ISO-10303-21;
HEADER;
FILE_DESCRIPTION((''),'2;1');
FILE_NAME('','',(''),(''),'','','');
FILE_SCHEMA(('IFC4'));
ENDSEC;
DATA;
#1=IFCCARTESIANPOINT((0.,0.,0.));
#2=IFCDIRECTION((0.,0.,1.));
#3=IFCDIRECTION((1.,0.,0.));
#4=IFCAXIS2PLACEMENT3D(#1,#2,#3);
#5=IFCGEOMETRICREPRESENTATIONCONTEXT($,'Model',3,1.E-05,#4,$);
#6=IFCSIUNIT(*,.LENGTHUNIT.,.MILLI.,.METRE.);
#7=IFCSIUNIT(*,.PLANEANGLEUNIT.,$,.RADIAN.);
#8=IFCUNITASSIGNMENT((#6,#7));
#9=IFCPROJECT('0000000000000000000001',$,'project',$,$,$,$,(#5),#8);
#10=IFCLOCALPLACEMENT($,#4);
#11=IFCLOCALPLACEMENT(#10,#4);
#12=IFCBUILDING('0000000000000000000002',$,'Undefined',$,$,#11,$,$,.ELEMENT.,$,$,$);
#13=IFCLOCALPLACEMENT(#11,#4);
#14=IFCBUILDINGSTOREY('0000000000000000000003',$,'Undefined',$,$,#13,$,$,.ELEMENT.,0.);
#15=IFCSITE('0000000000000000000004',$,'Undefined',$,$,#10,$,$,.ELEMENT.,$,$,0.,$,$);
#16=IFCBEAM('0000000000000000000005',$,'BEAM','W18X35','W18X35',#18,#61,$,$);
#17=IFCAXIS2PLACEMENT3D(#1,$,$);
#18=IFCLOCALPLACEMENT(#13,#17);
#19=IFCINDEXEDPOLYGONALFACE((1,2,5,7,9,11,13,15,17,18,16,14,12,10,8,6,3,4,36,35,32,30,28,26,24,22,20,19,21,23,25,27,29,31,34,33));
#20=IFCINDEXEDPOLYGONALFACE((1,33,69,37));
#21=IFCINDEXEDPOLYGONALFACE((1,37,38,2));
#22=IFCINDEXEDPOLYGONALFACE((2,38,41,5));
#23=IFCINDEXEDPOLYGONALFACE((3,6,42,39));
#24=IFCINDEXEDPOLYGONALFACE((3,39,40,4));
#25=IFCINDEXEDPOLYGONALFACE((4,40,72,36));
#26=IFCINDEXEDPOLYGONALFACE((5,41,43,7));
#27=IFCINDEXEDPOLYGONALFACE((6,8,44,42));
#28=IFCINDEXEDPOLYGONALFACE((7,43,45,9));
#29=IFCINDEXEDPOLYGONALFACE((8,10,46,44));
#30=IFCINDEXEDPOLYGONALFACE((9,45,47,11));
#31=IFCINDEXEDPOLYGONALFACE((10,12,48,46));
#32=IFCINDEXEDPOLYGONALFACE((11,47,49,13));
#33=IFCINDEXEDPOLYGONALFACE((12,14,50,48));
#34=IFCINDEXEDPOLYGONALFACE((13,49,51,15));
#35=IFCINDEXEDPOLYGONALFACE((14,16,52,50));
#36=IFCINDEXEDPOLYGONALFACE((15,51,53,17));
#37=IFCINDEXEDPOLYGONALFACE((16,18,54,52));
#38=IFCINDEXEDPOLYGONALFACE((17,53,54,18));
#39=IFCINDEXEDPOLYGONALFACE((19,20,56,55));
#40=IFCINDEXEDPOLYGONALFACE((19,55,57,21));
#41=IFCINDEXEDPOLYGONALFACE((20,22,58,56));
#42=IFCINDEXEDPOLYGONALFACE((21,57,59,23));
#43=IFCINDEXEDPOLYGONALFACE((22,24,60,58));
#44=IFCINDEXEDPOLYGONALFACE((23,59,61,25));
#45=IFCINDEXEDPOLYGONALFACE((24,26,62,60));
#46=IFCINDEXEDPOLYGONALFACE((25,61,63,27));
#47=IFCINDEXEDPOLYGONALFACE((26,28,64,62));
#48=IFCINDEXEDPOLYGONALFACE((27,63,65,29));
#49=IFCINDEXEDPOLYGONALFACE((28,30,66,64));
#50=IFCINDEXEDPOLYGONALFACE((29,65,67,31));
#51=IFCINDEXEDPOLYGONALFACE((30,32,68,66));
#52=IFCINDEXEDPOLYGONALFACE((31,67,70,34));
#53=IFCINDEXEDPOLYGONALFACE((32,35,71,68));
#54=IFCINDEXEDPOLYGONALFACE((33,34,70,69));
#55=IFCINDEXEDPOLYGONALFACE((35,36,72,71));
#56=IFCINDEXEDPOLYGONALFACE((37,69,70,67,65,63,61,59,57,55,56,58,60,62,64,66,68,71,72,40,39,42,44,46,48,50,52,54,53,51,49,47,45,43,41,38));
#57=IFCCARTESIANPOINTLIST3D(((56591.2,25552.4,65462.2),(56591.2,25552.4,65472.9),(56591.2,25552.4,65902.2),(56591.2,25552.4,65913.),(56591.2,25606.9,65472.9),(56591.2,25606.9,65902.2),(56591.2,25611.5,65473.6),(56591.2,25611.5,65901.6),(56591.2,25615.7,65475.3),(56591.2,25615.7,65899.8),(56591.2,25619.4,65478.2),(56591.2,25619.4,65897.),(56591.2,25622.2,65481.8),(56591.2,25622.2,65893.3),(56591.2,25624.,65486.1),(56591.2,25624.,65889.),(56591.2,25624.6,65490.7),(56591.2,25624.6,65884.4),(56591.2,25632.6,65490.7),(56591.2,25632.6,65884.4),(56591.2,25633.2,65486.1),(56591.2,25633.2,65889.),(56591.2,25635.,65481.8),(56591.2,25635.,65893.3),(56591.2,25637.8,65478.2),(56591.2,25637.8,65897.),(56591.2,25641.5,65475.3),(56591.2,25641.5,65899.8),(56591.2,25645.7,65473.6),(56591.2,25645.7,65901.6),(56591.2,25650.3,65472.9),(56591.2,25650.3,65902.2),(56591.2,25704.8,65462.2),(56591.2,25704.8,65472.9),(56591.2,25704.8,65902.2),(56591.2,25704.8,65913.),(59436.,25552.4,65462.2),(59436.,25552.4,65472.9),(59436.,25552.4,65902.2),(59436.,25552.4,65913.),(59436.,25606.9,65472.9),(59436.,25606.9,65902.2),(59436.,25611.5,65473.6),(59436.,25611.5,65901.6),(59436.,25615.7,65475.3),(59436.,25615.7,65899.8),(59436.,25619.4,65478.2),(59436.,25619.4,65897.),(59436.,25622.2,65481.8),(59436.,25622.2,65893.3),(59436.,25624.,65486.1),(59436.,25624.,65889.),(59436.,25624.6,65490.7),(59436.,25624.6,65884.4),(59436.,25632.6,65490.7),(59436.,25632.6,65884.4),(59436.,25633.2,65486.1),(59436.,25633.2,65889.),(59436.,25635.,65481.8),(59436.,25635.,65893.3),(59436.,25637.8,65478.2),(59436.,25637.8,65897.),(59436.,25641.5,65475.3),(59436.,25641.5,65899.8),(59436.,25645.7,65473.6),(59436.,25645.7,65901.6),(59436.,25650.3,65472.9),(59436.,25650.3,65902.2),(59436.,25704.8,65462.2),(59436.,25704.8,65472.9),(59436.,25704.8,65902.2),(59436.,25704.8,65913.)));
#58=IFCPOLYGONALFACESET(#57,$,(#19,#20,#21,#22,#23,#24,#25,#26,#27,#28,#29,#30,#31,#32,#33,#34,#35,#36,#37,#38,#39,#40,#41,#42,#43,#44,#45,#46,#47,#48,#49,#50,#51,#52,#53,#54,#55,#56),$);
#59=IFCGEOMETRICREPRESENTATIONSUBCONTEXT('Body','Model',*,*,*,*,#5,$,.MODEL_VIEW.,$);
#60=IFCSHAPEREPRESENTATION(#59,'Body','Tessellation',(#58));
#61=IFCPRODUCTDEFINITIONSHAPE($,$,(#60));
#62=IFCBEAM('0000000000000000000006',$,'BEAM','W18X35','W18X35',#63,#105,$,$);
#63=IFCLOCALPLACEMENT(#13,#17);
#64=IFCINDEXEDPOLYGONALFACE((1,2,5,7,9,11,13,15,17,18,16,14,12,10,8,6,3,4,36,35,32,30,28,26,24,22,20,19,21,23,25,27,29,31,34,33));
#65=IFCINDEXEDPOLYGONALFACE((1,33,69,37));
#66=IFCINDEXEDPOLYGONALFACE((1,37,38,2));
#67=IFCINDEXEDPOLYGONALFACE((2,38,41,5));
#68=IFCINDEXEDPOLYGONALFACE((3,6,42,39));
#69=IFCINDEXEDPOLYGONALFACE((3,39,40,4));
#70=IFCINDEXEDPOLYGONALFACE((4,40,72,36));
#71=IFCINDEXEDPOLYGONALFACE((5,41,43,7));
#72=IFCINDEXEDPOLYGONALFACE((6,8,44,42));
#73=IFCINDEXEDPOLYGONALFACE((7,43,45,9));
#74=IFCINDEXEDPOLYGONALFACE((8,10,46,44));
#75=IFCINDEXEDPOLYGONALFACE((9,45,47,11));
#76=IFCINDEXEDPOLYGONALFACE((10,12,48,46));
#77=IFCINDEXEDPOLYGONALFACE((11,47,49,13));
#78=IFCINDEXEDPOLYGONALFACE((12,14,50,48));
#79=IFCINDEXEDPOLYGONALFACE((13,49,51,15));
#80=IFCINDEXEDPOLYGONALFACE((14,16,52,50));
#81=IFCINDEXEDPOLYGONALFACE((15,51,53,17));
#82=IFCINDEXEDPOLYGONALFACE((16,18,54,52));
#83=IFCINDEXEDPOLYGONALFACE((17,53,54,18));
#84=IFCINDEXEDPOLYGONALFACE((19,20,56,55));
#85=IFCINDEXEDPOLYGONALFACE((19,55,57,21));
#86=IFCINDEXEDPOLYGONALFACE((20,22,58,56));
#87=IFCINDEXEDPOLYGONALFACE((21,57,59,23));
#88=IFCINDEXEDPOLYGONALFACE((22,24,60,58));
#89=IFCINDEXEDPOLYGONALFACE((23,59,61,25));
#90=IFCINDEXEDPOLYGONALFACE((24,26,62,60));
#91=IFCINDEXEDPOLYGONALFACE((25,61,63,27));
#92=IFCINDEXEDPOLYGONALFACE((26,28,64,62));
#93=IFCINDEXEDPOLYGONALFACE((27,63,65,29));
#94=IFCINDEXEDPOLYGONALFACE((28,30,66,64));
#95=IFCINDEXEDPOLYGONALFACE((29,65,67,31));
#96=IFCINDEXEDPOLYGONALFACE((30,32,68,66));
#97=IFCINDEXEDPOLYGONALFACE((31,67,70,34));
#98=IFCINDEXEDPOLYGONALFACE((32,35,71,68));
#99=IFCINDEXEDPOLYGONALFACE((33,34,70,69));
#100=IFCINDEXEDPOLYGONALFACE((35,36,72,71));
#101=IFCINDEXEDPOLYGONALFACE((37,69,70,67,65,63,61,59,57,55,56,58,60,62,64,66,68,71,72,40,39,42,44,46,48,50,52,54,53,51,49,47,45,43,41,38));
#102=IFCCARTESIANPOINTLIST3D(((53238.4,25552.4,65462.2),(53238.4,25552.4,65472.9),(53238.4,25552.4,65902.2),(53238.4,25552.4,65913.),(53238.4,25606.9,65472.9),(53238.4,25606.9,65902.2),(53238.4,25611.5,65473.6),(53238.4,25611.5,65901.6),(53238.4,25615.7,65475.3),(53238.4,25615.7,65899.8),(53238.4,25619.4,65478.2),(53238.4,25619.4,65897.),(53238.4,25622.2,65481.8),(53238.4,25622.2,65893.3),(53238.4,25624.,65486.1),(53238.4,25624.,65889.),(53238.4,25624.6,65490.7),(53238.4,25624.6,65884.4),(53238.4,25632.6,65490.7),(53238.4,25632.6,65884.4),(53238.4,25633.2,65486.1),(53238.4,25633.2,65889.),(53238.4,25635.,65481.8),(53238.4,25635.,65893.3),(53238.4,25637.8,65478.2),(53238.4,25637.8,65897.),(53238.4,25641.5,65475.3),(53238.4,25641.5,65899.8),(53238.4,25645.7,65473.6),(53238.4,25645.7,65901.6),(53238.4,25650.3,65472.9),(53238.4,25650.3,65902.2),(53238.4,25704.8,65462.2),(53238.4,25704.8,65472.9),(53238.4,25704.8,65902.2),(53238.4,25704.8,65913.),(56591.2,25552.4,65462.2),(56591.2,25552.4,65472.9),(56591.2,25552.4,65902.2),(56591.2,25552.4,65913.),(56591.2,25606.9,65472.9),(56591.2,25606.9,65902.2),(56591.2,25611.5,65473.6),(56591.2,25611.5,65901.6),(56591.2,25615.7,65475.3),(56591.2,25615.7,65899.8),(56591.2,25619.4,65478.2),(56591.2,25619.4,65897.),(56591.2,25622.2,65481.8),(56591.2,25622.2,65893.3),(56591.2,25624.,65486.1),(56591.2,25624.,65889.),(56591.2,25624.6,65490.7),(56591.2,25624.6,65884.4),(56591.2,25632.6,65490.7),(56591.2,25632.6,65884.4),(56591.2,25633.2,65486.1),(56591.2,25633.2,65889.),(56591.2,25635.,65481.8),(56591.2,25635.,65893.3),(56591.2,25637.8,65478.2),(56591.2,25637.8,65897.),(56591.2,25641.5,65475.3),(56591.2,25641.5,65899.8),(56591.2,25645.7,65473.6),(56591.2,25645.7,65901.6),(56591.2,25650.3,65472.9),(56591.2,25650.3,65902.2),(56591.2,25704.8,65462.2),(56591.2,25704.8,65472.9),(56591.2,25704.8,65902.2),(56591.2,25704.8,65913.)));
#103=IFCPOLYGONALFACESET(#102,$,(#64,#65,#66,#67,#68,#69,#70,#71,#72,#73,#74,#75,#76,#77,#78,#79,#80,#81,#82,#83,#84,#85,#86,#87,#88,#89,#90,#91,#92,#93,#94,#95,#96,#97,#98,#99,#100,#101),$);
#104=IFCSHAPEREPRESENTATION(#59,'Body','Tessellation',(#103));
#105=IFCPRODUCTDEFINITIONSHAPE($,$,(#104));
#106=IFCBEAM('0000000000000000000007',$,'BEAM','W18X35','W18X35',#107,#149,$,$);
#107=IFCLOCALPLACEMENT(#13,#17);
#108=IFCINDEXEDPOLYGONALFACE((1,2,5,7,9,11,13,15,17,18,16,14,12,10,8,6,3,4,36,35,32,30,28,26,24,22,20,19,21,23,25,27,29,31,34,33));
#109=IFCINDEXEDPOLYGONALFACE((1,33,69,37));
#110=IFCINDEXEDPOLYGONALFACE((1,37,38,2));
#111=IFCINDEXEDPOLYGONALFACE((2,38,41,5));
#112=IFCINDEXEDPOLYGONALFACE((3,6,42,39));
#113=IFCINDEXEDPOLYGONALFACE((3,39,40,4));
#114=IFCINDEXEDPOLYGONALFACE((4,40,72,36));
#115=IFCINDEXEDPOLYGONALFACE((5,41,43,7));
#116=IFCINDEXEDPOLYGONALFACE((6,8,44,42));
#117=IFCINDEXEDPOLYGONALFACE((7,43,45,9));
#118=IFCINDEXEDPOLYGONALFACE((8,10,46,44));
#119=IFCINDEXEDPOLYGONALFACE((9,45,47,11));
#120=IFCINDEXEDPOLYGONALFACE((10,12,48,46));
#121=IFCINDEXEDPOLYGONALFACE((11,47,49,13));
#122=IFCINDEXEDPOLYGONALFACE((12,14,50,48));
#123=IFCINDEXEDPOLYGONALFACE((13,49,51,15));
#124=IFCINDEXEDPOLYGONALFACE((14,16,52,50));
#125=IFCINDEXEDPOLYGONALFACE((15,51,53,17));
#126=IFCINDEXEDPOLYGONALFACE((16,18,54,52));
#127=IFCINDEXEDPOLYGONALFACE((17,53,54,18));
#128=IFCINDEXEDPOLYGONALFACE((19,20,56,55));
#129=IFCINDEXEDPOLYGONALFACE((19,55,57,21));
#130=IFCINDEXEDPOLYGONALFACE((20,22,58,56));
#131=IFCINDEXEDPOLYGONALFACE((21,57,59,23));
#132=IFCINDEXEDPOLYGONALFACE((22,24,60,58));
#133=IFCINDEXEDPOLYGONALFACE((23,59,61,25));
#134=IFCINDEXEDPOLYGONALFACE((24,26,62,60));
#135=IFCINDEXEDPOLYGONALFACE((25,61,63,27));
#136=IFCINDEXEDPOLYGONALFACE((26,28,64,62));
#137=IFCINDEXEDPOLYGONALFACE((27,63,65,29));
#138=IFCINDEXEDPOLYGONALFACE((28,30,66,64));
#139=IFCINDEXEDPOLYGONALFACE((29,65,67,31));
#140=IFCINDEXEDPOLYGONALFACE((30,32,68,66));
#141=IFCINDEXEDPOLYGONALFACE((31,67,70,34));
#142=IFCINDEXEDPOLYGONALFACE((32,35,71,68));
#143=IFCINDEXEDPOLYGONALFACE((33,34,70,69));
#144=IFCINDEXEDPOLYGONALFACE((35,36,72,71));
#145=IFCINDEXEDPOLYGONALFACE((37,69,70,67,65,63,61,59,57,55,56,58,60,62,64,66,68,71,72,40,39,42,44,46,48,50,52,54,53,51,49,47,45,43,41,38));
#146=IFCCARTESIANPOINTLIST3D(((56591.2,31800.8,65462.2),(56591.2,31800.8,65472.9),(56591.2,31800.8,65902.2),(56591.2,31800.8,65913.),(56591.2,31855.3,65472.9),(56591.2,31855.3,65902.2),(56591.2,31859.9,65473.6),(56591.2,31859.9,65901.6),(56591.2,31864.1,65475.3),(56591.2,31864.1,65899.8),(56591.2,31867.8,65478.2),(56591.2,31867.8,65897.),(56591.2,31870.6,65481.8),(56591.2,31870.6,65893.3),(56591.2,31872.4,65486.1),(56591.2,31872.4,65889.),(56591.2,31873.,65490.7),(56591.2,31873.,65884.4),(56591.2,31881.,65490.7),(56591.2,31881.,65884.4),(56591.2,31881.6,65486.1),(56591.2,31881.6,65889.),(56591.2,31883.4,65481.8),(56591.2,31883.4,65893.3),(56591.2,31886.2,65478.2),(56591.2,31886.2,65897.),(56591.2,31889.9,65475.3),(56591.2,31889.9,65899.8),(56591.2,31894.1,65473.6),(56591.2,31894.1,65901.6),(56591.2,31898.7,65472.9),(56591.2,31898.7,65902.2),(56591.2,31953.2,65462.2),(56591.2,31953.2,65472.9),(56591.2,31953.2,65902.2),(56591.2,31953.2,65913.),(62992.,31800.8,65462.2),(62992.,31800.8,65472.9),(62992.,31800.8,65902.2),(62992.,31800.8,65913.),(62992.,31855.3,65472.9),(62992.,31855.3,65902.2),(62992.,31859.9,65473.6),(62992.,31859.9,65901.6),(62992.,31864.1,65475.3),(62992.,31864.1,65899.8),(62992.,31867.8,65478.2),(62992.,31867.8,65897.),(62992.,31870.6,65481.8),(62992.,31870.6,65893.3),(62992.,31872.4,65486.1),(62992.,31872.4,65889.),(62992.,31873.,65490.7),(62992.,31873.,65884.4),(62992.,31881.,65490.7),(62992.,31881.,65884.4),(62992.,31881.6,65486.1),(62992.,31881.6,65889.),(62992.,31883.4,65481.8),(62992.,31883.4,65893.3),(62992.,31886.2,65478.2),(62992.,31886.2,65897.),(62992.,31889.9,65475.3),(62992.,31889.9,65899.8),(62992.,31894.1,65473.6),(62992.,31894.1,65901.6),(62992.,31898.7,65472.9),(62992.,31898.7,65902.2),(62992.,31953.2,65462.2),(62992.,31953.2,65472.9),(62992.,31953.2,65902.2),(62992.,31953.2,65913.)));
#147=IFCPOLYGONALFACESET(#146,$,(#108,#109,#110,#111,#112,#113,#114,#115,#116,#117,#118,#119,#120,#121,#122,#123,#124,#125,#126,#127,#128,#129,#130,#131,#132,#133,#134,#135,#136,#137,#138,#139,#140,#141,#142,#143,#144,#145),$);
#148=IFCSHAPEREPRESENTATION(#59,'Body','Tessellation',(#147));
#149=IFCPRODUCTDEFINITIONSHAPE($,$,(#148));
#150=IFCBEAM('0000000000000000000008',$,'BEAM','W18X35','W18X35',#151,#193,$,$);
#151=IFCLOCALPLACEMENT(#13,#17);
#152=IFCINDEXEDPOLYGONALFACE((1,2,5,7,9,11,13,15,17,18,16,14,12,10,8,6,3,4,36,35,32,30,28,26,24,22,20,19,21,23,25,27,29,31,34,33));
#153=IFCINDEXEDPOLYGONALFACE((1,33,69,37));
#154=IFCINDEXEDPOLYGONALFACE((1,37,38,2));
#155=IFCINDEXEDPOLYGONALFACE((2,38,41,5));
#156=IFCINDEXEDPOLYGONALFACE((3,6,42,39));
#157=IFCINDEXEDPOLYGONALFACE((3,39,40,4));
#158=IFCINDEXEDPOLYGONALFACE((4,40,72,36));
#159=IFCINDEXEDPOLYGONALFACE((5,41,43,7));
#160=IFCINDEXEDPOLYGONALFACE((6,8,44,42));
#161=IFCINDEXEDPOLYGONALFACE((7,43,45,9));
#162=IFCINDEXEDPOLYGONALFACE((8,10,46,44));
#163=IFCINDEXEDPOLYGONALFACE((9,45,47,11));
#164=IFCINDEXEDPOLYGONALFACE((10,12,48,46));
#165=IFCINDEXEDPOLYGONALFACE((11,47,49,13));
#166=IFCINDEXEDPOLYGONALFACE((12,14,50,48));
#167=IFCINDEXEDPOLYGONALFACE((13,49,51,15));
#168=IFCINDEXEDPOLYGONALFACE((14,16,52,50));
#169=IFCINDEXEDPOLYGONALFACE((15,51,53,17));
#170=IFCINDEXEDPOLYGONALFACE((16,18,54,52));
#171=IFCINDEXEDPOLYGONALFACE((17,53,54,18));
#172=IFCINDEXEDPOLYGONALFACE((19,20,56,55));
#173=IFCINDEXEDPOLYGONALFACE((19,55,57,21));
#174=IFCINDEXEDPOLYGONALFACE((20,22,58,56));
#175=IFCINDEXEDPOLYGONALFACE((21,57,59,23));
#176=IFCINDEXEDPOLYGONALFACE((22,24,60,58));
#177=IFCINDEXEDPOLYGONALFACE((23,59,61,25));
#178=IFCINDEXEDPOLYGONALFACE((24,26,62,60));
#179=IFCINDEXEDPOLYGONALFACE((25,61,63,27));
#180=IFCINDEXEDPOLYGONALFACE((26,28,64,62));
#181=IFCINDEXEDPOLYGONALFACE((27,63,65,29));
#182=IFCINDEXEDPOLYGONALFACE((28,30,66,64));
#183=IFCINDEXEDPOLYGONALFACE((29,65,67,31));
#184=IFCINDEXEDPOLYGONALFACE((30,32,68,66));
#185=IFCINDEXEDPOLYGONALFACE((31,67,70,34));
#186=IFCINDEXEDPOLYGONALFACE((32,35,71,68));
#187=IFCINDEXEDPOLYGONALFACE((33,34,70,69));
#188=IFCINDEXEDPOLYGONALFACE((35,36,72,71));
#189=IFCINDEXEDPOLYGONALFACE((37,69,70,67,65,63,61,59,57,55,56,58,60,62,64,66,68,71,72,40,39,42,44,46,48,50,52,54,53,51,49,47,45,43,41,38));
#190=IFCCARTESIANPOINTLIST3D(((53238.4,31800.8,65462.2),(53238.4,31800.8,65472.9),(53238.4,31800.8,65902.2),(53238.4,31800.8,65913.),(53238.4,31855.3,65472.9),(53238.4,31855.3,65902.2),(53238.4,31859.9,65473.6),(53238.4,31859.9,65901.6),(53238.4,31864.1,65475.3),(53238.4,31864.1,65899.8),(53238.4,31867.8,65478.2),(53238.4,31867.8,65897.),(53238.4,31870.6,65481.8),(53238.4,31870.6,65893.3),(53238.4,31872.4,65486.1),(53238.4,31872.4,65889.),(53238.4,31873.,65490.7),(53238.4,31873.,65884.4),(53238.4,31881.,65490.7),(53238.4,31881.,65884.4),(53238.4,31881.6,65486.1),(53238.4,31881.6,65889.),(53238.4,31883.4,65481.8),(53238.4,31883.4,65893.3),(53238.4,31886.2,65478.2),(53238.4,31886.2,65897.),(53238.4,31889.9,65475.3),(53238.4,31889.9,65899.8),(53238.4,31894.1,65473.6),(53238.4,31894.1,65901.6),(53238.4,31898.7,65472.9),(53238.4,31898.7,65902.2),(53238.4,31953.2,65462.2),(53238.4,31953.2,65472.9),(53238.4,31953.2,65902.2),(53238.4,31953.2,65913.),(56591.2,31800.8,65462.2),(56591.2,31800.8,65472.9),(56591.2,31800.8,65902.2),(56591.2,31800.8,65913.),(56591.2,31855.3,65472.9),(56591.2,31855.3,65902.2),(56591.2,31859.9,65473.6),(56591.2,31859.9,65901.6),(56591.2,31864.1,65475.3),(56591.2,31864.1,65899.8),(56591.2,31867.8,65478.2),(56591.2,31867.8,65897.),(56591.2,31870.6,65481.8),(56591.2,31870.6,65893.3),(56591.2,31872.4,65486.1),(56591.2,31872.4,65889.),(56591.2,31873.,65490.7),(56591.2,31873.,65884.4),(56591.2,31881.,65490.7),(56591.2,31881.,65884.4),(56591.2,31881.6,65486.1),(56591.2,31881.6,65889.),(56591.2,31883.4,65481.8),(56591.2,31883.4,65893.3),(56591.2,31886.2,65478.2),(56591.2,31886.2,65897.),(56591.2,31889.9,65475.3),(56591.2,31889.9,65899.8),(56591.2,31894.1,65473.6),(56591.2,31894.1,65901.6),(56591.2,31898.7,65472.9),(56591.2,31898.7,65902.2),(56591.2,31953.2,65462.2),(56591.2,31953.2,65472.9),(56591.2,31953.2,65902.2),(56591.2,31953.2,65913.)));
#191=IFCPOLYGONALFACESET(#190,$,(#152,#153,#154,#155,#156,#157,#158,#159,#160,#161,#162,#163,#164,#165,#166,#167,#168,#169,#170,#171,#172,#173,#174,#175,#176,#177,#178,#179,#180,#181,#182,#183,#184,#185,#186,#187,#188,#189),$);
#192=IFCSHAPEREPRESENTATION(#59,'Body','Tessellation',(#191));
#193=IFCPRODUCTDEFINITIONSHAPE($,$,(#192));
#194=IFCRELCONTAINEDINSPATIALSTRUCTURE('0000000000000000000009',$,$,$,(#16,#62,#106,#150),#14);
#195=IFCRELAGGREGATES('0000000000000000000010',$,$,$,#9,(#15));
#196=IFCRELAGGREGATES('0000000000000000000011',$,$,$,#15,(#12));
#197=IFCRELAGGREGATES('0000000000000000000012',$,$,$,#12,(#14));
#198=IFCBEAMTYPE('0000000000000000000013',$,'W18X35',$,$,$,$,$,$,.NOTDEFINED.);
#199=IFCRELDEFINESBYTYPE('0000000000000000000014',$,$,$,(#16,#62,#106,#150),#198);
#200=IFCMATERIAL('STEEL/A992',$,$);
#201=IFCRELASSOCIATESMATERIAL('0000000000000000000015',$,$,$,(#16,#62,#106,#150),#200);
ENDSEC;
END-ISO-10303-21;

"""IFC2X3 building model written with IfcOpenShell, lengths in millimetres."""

from ifc_helpers import new_model, si_unit, frame, origin_with_axes, origin_2d_with_axis, place, context, subcontext, project, spatial, i_section, extrude, material, type_object, element, save


model = new_model("IFC2X3")

# Units and contexts
model_context = context("Model", 3, precision=1e-05, world=origin_with_axes())
body_context = subcontext(model_context, "Body", "Model", "MODEL_VIEW")
ifc_project = project(units=[si_unit("LENGTHUNIT", "METRE", prefix="MILLI"), si_unit("PLANEANGLEUNIT", "RADIAN")], contexts=[model_context])

# Site, building, storey
site_placement = place(None, origin_with_axes())
site = spatial("IfcSite", under=ifc_project, at=site_placement, Name="Undefined", CompositionType="ELEMENT", RefElevation=0.0)
building_placement = place(site_placement, origin_with_axes())
building = spatial("IfcBuilding", under=site, at=building_placement, Name="Undefined", CompositionType="ELEMENT")
storey_placement = place(building_placement, origin_with_axes())
storey = spatial("IfcBuildingStorey", under=building, at=storey_placement, Name="Undefined", CompositionType="ELEMENT", Elevation=0.0)

# Beams
ifc_material_1 = material(Name="STEEL/A992")
beam_type_1 = type_object("IfcBeamType", Name="W18X35", PredefinedType="NOTDEFINED")
beam_1_placement = place(storey_placement, frame((56591.2, 25628.6, 65687.6), z_axis=(0.0, 0.0, 1.0), x_axis=(1.0, 0.0, 0.0)))
element("IfcBeam", 1, at=beam_1_placement, inside=storey, type_object=beam_type_1, material=ifc_material_1, Name="BEAM", Description="W18X35", ObjectType="W18X35", context=body_context, shape_type="SweptSolid", body=[
    extrude(i_section(OverallWidth=152.4, OverallDepth=450.9, WebThickness=7.9, FlangeThickness=10.8, FilletRadius=17.8, at=origin_2d_with_axis()), frame((2844.8, 0.0, 0.0), z_axis=(-1.0, 0.0, 0.0), x_axis=(0.0, -1.0, 0.0)), (0.0, 0.0, 1.0), 2844.8),
])
beam_2_placement = place(storey_placement, frame((53238.4, 25628.6, 65687.6), z_axis=(0.0, 0.0, 1.0), x_axis=(1.0, 0.0, 0.0)))
element("IfcBeam", 2, at=beam_2_placement, inside=storey, type_object=beam_type_1, material=ifc_material_1, Name="BEAM", Description="W18X35", ObjectType="W18X35", context=body_context, shape_type="SweptSolid", body=[
    extrude(i_section(OverallWidth=152.4, OverallDepth=450.9, WebThickness=7.9, FlangeThickness=10.8, FilletRadius=17.8, at=origin_2d_with_axis()), frame((3352.8, 0.0, 0.0), z_axis=(-1.0, 0.0, 0.0), x_axis=(0.0, -1.0, 0.0)), (0.0, 0.0, 1.0), 3352.8),
])
beam_3_placement = place(storey_placement, frame((56591.2, 31877.0, 65687.6), z_axis=(0.0, 0.0, 1.0), x_axis=(1.0, 0.0, 0.0)))
element("IfcBeam", 3, at=beam_3_placement, inside=storey, type_object=beam_type_1, material=ifc_material_1, Name="BEAM", Description="W18X35", ObjectType="W18X35", context=body_context, shape_type="SweptSolid", body=[
    extrude(i_section(OverallWidth=152.4, OverallDepth=450.9, WebThickness=7.9, FlangeThickness=10.8, FilletRadius=17.8, at=origin_2d_with_axis()), frame((6400.8, 0.0, 0.0), z_axis=(-1.0, 0.0, 0.0), x_axis=(0.0, -1.0, 0.0)), (0.0, 0.0, 1.0), 6400.8),
])
beam_4_placement = place(storey_placement, frame((53238.4, 31877.0, 65687.6), z_axis=(0.0, 0.0, 1.0), x_axis=(1.0, 0.0, 0.0)))
element("IfcBeam", 4, at=beam_4_placement, inside=storey, type_object=beam_type_1, material=ifc_material_1, Name="BEAM", Description="W18X35", ObjectType="W18X35", context=body_context, shape_type="SweptSolid", body=[
    extrude(i_section(OverallWidth=152.4, OverallDepth=450.9, WebThickness=7.9, FlangeThickness=10.8, FilletRadius=17.8, at=origin_2d_with_axis()), frame((3352.8, 0.0, 0.0), z_axis=(-1.0, 0.0, 0.0), x_axis=(0.0, -1.0, 0.0)), (0.0, 0.0, 1.0), 3352.8),
])

save(model, "model.ifc")
